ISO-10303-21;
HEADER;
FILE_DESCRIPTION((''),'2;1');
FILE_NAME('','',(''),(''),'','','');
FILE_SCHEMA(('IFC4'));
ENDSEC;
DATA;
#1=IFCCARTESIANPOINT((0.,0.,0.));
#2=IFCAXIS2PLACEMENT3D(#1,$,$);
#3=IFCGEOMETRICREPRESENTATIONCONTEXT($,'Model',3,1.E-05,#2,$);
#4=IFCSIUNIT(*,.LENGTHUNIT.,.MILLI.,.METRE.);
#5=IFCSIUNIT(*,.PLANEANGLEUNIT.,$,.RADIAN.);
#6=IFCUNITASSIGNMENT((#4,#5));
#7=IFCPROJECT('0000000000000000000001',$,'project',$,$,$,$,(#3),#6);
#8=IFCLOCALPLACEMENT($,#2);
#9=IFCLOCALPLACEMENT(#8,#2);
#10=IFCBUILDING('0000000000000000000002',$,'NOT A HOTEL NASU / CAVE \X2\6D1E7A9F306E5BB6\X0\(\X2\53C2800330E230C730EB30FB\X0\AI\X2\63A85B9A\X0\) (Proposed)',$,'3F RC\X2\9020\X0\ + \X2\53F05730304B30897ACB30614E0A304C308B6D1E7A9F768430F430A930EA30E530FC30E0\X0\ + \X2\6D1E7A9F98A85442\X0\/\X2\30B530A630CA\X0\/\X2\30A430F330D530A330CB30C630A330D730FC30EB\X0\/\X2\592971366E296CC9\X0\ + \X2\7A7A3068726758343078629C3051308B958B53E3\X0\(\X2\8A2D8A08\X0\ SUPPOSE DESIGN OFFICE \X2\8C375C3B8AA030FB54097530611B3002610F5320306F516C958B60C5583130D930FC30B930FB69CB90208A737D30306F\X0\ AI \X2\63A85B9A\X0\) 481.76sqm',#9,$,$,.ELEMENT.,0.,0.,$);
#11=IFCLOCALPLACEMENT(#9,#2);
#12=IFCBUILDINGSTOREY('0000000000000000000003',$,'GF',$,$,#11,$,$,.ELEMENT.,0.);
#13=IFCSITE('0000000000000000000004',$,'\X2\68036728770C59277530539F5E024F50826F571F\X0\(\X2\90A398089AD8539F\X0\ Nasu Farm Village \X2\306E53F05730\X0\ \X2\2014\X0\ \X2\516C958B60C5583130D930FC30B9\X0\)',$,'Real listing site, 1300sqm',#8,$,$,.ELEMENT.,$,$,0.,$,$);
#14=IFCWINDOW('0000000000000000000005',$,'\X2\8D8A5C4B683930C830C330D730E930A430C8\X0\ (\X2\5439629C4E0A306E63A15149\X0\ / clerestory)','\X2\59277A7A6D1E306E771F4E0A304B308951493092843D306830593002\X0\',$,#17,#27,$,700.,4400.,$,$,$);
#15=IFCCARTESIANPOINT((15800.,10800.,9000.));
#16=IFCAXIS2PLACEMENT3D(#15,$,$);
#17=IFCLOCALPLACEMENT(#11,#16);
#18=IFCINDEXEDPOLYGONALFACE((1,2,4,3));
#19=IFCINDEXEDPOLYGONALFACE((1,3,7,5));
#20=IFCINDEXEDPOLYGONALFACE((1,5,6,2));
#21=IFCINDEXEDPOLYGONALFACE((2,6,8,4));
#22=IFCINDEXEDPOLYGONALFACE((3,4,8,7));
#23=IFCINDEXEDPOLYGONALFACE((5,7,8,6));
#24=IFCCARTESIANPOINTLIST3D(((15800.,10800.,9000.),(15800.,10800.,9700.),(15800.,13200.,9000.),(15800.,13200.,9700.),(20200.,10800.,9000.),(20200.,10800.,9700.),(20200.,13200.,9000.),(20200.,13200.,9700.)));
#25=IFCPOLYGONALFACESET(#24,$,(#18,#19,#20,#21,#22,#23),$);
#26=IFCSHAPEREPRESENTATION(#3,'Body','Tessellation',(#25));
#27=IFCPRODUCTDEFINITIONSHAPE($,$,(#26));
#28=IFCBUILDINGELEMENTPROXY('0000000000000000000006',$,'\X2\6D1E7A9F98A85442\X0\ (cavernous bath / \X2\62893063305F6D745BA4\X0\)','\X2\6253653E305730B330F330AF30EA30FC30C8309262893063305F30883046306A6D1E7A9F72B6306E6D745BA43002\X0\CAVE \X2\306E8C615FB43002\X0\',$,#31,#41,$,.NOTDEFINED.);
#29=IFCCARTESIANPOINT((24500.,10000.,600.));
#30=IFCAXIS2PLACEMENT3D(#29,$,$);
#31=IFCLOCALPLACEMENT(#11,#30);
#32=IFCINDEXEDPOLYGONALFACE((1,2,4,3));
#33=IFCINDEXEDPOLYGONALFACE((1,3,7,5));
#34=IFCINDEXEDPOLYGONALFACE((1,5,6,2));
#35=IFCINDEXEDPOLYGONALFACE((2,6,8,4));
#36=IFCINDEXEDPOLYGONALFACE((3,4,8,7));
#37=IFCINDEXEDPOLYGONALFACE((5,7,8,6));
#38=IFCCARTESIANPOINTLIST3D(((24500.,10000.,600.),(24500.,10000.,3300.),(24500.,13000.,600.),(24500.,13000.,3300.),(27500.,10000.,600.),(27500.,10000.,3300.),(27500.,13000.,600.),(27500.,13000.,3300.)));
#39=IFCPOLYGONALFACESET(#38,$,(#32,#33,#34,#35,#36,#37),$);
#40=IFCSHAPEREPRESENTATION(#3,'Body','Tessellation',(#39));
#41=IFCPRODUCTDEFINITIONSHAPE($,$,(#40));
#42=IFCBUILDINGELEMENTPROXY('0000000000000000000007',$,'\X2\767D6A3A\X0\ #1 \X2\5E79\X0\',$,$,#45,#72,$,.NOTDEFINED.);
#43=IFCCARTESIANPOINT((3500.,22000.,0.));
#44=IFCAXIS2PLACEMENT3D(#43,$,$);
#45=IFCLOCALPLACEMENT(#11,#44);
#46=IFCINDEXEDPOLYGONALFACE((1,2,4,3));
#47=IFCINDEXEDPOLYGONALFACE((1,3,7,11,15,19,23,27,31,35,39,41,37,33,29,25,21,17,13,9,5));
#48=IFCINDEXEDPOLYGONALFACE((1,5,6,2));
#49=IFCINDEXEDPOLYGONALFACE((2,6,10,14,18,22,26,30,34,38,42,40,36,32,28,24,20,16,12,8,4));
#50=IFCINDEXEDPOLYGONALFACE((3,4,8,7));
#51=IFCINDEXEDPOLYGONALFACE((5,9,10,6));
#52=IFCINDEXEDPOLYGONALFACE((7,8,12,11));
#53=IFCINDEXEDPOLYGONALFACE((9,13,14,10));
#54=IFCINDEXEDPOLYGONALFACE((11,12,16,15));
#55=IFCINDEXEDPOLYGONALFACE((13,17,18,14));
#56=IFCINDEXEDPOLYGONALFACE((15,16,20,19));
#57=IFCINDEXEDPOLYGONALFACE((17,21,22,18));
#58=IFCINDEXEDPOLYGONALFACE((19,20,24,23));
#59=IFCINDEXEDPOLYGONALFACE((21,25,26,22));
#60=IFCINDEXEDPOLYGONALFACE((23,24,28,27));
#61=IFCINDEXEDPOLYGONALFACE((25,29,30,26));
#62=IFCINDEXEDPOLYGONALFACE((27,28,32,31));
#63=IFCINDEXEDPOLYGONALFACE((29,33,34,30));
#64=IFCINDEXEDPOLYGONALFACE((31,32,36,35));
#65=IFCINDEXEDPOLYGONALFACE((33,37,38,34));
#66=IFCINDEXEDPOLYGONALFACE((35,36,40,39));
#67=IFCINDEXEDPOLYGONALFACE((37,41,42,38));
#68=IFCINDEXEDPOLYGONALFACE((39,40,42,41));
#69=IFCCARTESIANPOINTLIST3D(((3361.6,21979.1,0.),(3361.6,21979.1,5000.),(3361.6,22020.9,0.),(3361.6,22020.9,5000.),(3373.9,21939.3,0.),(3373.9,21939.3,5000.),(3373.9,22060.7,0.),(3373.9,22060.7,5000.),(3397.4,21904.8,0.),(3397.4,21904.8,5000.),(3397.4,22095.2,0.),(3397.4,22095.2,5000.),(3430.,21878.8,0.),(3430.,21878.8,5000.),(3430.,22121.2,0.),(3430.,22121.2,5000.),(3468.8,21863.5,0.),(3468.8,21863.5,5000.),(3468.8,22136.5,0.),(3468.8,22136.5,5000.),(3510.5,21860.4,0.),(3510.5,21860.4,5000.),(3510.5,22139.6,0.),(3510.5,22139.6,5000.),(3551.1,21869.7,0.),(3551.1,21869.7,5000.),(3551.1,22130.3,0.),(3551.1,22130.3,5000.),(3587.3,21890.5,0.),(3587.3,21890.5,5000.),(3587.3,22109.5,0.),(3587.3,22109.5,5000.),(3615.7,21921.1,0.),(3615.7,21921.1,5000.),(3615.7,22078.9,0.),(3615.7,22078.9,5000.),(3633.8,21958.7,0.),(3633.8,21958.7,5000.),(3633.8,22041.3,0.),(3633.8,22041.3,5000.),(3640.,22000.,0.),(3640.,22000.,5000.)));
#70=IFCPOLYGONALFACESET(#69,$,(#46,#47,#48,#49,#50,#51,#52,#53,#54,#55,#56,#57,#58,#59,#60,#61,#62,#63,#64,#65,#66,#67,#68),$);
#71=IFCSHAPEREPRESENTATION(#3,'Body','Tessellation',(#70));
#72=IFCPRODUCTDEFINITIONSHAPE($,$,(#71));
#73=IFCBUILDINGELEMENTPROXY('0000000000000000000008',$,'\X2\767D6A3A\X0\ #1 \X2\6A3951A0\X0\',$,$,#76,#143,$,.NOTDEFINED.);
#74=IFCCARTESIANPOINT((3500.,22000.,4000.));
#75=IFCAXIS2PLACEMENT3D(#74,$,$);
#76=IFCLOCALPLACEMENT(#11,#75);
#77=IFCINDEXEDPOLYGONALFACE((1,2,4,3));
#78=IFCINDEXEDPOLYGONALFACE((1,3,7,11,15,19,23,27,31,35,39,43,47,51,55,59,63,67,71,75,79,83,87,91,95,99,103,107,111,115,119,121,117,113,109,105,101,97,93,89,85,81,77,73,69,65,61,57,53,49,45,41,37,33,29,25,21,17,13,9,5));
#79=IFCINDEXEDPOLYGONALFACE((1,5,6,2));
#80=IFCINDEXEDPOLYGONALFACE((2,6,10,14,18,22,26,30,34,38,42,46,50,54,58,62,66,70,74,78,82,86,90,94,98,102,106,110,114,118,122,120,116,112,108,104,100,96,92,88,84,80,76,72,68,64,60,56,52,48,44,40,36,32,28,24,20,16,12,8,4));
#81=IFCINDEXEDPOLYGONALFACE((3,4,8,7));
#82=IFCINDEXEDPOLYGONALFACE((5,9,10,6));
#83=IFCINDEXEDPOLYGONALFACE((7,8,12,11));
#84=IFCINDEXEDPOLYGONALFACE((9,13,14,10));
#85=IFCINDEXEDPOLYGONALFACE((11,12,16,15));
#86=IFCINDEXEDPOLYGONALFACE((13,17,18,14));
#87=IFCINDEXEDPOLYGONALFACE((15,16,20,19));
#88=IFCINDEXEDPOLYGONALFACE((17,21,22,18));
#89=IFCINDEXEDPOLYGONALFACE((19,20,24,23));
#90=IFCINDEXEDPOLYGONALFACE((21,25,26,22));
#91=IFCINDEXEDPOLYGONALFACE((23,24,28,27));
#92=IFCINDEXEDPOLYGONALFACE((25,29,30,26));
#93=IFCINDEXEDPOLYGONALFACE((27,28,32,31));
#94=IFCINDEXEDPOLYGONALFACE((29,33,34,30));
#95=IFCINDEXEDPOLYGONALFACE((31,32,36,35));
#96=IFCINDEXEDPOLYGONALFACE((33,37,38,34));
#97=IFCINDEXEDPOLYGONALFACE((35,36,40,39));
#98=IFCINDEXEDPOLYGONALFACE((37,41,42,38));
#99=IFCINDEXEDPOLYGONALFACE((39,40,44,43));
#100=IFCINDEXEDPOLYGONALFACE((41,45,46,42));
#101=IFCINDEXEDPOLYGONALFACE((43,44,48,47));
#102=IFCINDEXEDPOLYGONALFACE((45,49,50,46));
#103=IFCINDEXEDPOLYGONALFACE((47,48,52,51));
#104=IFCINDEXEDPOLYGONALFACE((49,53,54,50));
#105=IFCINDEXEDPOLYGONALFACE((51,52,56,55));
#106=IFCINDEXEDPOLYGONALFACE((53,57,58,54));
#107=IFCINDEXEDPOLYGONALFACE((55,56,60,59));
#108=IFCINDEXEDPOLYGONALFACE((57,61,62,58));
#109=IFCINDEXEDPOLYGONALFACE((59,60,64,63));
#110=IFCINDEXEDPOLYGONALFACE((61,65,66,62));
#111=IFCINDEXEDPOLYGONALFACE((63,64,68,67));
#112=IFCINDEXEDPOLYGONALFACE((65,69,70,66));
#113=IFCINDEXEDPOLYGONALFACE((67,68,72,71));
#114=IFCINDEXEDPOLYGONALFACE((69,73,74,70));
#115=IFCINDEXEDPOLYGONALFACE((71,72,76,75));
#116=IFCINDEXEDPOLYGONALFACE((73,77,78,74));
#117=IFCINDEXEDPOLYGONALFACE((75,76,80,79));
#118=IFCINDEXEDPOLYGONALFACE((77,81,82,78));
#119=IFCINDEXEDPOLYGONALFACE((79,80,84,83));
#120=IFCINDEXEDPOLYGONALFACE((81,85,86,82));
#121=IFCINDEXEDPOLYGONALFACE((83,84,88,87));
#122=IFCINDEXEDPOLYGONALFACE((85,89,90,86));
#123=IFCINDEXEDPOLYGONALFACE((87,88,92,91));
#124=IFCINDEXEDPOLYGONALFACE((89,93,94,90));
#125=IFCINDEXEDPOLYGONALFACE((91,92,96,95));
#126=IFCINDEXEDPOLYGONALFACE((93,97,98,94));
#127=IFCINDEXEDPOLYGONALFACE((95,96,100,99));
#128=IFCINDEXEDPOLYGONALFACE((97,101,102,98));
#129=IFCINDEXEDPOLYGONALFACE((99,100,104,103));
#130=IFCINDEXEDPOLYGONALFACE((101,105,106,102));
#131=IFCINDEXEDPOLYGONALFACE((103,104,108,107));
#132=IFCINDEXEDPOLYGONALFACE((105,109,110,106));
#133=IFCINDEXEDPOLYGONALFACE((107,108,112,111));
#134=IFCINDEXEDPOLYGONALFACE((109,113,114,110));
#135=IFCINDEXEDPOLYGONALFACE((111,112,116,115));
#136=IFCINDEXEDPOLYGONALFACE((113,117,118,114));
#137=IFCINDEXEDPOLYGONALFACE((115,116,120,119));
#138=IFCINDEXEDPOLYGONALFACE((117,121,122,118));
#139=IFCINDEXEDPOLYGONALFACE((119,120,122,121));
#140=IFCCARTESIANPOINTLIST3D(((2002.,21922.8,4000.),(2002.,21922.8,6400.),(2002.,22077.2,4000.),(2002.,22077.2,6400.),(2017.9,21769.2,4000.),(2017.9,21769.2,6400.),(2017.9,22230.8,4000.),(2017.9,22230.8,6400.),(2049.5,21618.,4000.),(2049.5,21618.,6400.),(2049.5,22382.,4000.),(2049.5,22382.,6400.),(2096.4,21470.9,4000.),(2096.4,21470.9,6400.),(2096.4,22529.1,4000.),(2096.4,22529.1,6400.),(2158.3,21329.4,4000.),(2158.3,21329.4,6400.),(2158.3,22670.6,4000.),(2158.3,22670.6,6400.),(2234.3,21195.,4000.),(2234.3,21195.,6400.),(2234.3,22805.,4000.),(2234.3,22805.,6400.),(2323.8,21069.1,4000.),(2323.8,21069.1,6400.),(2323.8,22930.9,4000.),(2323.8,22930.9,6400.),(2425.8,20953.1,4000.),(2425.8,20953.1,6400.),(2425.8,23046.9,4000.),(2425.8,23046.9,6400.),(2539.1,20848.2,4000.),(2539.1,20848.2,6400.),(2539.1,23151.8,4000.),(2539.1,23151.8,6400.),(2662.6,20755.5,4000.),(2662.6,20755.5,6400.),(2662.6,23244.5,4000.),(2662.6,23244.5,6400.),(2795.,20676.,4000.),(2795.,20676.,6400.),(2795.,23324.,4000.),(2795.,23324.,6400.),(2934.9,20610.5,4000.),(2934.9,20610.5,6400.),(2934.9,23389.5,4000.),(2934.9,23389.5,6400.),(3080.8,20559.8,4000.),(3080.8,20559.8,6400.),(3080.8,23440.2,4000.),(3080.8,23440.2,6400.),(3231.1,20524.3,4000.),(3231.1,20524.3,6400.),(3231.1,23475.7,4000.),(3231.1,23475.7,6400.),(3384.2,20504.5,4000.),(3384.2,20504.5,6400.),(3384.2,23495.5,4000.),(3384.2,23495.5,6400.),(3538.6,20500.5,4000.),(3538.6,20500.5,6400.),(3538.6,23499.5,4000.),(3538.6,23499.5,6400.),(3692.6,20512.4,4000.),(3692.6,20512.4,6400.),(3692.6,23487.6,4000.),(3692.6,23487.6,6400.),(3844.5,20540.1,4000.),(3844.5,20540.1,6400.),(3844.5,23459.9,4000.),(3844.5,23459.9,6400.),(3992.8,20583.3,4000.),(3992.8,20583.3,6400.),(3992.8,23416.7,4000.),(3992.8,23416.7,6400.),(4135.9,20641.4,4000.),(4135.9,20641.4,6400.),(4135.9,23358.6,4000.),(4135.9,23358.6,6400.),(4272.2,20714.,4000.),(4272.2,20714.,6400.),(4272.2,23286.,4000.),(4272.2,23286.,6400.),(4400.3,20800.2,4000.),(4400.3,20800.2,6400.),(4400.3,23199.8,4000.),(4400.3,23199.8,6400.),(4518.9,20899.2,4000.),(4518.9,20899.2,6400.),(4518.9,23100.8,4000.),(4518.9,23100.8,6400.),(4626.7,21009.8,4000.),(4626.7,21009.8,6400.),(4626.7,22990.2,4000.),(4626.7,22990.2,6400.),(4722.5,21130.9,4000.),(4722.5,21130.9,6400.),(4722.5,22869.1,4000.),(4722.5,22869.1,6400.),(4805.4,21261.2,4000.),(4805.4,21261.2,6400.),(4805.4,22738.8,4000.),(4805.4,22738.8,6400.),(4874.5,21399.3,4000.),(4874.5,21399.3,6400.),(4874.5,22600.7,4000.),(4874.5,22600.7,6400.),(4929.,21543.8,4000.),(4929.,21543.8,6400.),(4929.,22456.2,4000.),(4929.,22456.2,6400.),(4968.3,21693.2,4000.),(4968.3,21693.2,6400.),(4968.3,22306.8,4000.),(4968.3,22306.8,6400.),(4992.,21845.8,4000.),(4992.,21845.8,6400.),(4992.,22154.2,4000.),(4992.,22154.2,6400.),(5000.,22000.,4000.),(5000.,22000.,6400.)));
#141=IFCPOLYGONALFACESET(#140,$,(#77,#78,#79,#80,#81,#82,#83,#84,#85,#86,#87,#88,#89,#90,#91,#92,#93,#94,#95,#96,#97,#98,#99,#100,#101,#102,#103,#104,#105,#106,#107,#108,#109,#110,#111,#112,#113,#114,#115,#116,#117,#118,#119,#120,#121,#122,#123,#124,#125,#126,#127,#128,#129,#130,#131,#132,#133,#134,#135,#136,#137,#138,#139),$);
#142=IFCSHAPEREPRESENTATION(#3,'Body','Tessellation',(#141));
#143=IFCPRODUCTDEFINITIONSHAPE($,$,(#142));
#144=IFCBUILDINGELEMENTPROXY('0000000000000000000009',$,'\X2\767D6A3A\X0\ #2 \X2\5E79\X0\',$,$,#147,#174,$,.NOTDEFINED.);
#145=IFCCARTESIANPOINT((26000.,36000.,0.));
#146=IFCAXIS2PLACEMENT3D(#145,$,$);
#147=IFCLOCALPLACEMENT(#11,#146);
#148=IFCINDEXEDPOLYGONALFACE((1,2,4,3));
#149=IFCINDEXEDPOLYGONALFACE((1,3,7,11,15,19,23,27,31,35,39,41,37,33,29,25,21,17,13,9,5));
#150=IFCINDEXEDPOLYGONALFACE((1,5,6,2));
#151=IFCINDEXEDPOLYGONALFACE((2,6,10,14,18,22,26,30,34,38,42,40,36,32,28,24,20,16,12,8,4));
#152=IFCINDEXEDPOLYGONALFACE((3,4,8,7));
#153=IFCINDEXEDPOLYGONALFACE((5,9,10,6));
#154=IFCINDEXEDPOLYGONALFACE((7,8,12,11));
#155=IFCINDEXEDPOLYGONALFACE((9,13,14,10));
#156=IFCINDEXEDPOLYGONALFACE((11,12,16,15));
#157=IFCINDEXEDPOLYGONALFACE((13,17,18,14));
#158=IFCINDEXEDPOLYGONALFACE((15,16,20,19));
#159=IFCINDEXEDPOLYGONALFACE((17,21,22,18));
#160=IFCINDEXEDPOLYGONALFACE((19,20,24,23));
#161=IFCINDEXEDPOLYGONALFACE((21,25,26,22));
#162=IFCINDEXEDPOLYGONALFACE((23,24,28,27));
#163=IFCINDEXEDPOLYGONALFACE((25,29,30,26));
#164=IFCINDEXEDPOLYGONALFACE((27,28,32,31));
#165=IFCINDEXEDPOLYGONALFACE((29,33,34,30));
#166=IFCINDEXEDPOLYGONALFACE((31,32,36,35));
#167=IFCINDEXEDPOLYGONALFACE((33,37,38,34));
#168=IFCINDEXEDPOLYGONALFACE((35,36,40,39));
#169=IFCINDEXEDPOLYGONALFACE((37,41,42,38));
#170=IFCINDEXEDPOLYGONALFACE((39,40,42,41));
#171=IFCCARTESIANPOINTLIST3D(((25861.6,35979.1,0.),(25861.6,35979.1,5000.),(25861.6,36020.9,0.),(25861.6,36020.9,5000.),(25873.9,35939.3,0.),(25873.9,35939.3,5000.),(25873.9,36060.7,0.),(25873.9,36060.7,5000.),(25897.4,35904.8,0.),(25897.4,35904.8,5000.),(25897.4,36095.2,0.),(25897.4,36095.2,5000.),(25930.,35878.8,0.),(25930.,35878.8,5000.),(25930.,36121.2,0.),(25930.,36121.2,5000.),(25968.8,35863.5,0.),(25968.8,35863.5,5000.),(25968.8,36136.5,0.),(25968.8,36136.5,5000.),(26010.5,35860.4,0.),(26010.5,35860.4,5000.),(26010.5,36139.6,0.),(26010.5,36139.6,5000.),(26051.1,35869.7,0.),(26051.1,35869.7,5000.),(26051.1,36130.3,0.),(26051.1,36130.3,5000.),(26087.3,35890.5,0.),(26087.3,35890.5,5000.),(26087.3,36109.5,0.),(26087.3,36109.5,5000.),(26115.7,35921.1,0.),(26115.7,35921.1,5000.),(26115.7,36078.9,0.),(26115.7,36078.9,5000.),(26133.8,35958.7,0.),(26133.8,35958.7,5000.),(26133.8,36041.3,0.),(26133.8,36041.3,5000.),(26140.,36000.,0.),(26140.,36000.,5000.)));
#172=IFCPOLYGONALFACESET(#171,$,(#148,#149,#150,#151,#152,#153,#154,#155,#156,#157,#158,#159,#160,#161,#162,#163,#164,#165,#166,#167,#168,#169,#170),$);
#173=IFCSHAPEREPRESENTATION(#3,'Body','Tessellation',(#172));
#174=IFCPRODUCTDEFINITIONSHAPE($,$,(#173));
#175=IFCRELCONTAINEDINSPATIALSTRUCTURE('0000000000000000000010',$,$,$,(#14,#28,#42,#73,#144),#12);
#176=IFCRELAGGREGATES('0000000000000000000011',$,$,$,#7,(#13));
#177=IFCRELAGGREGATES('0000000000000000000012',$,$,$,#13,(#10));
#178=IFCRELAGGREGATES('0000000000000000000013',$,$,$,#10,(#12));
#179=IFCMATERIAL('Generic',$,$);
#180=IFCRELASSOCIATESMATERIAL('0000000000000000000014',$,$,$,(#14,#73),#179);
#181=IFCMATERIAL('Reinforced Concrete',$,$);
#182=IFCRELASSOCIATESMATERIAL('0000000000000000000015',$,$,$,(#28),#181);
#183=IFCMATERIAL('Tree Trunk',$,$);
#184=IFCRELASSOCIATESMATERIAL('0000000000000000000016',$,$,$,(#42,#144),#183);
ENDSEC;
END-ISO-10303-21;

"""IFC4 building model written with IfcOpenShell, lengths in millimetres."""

from ifc_helpers import new_model, si_unit, frame, frame_2d, origin, origin_2d, place, context, project, spatial, rectangle, circle, extrude, material, element, save


model = new_model("IFC4")

# Units and contexts
model_context = context("Model", 3, precision=1e-05, world=origin())
ifc_project = project(units=[si_unit("LENGTHUNIT", "METRE", prefix="MILLI"), si_unit("PLANEANGLEUNIT", "RADIAN")], contexts=[model_context])

# Site, building, storey
site_placement = place(None, origin())
site = spatial("IfcSite", under=ifc_project, at=site_placement, Name="栃木県大田原市佐良土(那須高原 Nasu Farm Village の台地 — 公開情報ベース)", ObjectType="Real listing site, 1300sqm", CompositionType="ELEMENT", RefElevation=0.0)
building_placement = place(site_placement, origin())
building = spatial("IfcBuilding", under=site, at=building_placement, Name="NOT A HOTEL NASU / CAVE 洞窟の家(参考モデル・AI推定) (Proposed)", ObjectType="3F RC造 + 台地から立ち上がる洞窟的ヴォリューム + 洞窟風呂/サウナ/インフィニティプール/天然温泉 + 空と牧場へ抜ける開口(設計 SUPPOSE DESIGN OFFICE 谷尻誠・吉田愛。意匠は公開情報ベース・構造詳細は AI 推定) 481.76sqm", CompositionType="ELEMENT", ElevationOfRefHeight=0.0, ElevationOfTerrain=0.0)
storey_placement = place(building_placement, origin())
storey = spatial("IfcBuildingStorey", under=building, at=storey_placement, Name="GF", CompositionType="ELEMENT", Elevation=0.0)

# Shared definitions
ifc_material_1 = material(Name="Reinforced Concrete")

# Shared definitions
ifc_material_2 = material(Name="Generic")

# Window
window_1_placement = place(storey_placement, frame((15800.0, 10800.0, 9000.0)))
element("IfcWindow", 1, at=window_1_placement, inside=storey, material=ifc_material_2, Name="越屋根トップライト (吹抜上の採光 / clerestory)", Description="大空洞の真上から光を落とす。", OverallHeight=700.0, OverallWidth=4400.0, context=model_context, shape_type="SweptSolid", body=[
    extrude(rectangle(XDim=4400.0, YDim=2400.0, at=frame_2d((2200.0, 1200.0))), frame((15800.0, 10800.0, 9000.0)), (0.0, 0.0, 1.0), 700.0),
])

# Building element proxies
proxy_1_placement = place(storey_placement, frame((24500.0, 10000.0, 600.0)))
element("IfcBuildingElementProxy", 2, at=proxy_1_placement, inside=storey, material=ifc_material_1, Name="洞窟風呂 (cavernous bath / 抉った浴室)", Description="打放しコンクリートを抉ったような洞窟状の浴室。CAVE の象徴。", PredefinedType="NOTDEFINED", context=model_context, shape_type="SweptSolid", body=[
    extrude(rectangle(XDim=3000.0, YDim=3000.0, at=frame_2d((1500.0, 1500.0))), frame((24500.0, 10000.0, 600.0)), (0.0, 0.0, 1.0), 2700.0),
])
ifc_material_3 = material(Name="Tree Trunk")
proxy_2_placement = place(storey_placement, frame((3500.0, 22000.0, 0.0)))
element("IfcBuildingElementProxy", 3, at=proxy_2_placement, inside=storey, material=ifc_material_3, Name="白樺 #1 幹", PredefinedType="NOTDEFINED", context=model_context, shape_type="SweptSolid", body=[
    extrude(circle(Radius=140.0, at=origin_2d()), frame((3500.0, 22000.0, 0.0)), (0.0, 0.0, 1.0), 5000.0),
])
proxy_3_placement = place(storey_placement, frame((3500.0, 22000.0, 4000.0)))
element("IfcBuildingElementProxy", 4, at=proxy_3_placement, inside=storey, material=ifc_material_2, Name="白樺 #1 樹冠", PredefinedType="NOTDEFINED", context=model_context, shape_type="SweptSolid", body=[
    extrude(circle(Radius=1500.0, at=origin_2d()), frame((3500.0, 22000.0, 4000.0)), (0.0, 0.0, 1.0), 2400.0),
])
proxy_4_placement = place(storey_placement, frame((26000.0, 36000.0, 0.0)))
element("IfcBuildingElementProxy", 5, at=proxy_4_placement, inside=storey, material=ifc_material_3, Name="白樺 #2 幹", PredefinedType="NOTDEFINED", context=model_context, shape_type="SweptSolid", body=[
    extrude(circle(Radius=140.0, at=origin_2d()), frame((26000.0, 36000.0, 0.0)), (0.0, 0.0, 1.0), 5000.0),
])

save(model, "model.ifc")
